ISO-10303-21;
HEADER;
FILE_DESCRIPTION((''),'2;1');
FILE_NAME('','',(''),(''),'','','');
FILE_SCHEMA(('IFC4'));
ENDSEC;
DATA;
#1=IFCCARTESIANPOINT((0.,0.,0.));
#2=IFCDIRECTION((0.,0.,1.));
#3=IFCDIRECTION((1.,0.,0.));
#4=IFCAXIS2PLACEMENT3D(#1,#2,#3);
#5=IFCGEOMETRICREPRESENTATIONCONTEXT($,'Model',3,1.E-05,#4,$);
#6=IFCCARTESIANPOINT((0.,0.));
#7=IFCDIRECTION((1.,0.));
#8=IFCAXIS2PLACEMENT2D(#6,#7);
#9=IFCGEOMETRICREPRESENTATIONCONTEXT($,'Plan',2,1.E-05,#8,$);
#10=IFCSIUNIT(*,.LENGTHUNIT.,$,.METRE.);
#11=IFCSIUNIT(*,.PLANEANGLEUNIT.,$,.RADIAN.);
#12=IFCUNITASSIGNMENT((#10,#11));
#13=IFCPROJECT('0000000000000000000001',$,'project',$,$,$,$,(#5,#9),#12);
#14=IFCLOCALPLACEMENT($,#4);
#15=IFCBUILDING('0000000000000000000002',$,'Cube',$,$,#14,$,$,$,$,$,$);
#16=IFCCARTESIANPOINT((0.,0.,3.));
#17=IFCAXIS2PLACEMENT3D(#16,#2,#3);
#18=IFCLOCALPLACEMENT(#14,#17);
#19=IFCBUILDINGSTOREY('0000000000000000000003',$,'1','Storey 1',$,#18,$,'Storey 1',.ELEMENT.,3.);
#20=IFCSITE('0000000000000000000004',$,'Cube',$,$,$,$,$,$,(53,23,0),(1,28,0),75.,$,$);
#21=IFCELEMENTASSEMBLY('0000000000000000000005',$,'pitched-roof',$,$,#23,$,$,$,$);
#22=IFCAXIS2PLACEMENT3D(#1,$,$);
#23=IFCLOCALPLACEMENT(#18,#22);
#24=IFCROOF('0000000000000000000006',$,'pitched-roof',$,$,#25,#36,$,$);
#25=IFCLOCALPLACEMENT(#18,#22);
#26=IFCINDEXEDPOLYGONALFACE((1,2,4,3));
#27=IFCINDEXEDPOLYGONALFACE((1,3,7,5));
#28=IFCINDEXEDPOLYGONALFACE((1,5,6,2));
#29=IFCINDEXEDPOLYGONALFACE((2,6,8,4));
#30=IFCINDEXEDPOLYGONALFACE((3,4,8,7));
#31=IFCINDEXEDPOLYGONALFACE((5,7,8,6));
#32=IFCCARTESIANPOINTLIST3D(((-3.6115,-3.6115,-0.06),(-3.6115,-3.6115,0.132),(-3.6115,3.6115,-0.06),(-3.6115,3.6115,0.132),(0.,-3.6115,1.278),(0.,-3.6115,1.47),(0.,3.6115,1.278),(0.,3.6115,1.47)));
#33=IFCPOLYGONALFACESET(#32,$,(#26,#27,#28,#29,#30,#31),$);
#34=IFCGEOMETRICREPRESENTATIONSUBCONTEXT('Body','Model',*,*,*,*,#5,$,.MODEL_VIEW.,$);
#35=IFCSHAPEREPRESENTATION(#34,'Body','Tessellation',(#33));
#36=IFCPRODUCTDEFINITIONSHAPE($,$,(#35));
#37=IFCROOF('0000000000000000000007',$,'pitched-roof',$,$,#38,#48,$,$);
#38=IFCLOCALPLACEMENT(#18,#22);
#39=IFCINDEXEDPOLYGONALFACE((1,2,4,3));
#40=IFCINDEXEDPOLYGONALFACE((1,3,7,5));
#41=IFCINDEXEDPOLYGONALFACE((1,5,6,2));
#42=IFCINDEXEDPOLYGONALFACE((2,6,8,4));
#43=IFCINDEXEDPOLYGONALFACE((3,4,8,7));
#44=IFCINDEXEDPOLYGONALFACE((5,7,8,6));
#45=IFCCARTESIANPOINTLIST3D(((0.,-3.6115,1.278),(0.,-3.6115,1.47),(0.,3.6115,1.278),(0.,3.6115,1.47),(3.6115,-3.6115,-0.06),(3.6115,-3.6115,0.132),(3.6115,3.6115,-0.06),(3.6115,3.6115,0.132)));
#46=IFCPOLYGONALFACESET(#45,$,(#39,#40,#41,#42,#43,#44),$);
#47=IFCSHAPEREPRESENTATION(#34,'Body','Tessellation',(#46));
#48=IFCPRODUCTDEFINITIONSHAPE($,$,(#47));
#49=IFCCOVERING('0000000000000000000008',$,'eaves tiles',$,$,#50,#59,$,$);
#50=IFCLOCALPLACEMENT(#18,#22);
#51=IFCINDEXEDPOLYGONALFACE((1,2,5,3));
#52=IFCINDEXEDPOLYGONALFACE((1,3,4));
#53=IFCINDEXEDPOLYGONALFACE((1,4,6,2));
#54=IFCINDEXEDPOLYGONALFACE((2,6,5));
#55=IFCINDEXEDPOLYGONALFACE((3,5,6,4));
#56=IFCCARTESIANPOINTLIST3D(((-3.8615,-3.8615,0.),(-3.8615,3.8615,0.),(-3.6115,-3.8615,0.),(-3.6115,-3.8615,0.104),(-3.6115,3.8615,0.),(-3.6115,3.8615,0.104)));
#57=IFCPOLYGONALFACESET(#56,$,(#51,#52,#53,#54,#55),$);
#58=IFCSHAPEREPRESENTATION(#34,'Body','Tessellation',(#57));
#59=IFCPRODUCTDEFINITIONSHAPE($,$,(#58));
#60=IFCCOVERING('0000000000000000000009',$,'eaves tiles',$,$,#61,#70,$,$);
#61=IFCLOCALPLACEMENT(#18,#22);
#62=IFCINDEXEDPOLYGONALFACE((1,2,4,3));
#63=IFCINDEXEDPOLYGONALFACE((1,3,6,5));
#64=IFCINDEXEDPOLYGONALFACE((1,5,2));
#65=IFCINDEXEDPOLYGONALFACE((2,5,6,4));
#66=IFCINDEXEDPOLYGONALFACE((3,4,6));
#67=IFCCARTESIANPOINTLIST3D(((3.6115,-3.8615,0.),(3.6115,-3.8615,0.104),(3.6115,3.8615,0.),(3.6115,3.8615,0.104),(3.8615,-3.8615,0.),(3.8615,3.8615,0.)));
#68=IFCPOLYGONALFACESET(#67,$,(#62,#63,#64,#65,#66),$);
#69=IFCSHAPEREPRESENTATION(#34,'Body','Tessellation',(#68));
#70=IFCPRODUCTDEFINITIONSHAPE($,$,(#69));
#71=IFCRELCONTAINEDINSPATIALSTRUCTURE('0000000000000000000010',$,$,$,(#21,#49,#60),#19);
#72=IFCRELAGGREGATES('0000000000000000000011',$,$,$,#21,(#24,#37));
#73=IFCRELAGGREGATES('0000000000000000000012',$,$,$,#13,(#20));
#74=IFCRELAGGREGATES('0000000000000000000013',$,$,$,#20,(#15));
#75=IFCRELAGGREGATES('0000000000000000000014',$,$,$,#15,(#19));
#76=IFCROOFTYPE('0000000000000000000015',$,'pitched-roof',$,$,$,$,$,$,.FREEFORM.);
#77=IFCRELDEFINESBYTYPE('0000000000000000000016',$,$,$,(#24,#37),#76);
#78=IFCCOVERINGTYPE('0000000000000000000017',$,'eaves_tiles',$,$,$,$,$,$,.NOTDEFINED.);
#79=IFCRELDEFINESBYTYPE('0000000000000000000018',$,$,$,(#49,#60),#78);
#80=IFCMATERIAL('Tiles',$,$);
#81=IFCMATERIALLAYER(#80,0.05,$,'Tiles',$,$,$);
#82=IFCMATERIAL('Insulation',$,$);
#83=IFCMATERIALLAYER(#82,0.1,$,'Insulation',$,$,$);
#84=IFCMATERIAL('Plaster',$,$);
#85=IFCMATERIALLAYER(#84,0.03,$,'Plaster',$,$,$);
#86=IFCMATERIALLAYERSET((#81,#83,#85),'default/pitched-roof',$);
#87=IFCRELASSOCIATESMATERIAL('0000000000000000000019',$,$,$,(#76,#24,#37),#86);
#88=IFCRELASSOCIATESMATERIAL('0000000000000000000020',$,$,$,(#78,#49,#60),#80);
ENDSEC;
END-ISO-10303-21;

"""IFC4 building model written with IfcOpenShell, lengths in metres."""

from ifc_helpers import new_model, si_unit, frame, origin, origin_with_axes, origin_2d_with_axis, place, context, subcontext, project, spatial, polyline, outline, extrude, material, layer, layer_set, layer_usage, material_profile, profile_set, profile_usage, type_object, element, aggregate, save


model = new_model("IFC4")

# Units and contexts
model_context = context("Model", 3, precision=1e-05, world=origin_with_axes())
plan_context = context("Plan", 2, precision=1e-05, world=origin_2d_with_axis())
body_context = subcontext(model_context, "Body", "Model", "MODEL_VIEW")
ifc_project = project(units=[si_unit("LENGTHUNIT", "METRE"), si_unit("PLANEANGLEUNIT", "RADIAN")], contexts=[model_context, plan_context])

# Site, building, storey
site = spatial("IfcSite", under=ifc_project, Name="Cube", RefLatitude=(53, 23, 0), RefLongitude=(1, 28, 0), RefElevation=75.0)
building_placement = place(None, origin_with_axes())
building = spatial("IfcBuilding", under=site, at=building_placement, Name="Cube")
storey_placement = place(building_placement, frame((0.0, 0.0, 3.0), z_axis=(0.0, 0.0, 1.0), x_axis=(1.0, 0.0, 0.0)))
storey = spatial("IfcBuildingStorey", under=building, at=storey_placement, Name="1", Description="Storey 1", LongName="Storey 1", CompositionType="ELEMENT", Elevation=3.0)

# Element assembly, roofs
assembly_placement = place(storey_placement, frame((0.0, 0.0, -3.0), z_axis=(0.0, 0.0, 1.0), x_axis=(1.0, 0.0, 0.0)))
assembly = element("IfcElementAssembly", 1, at=assembly_placement, inside=storey, Name="pitched-roof")
ifc_material_1 = material(Name="Tiles")
ifc_layer_1 = layer(ifc_material_1, 0.05, Name="Tiles")
ifc_material_2 = material(Name="Insulation")
ifc_layer_2 = layer(ifc_material_2, 0.1, Name="Insulation")
ifc_material_3 = material(Name="Plaster")
ifc_layer_3 = layer(ifc_material_3, 0.03, Name="Plaster")
ifc_layer_set = layer_set([ifc_layer_1, ifc_layer_2, ifc_layer_3], Name="default/pitched-roof")
ifc_layer_usage_1 = layer_usage(ifc_layer_set, "AXIS3", "POSITIVE", 0.0)
roof_type = type_object("IfcRoofType", Name="pitched-roof", PredefinedType="FREEFORM", material=ifc_layer_set)
roof_1_placement = place(assembly_placement, frame((-3.6115, 3.6115, 2.94), z_axis=(-0.347413, 0.0, 0.937712), x_axis=(0.0, -1.0, 0.0)))
roof_1 = element("IfcRoof", 2, at=roof_1_placement, type_object=roof_type, material=ifc_layer_usage_1, Name="pitched-roof", context=body_context, shape_type="SweptSolid", body=[
    extrude(outline(polyline([(0.0, 0.0), (7.223, 0.0), (7.223, 3.8514), (0.0, 3.8514), (0.0, 0.0)])), origin(), (0.0, 0.347413, 0.937712), 0.192),
])
ifc_layer_usage_2 = layer_usage(ifc_layer_set, "AXIS3", "POSITIVE", 0.0)
roof_2_placement = place(assembly_placement, frame((3.6115, -3.6115, 2.94), z_axis=(0.347413, 0.0, 0.937712), x_axis=(0.0, 1.0, 0.0)))
roof_2 = element("IfcRoof", 3, at=roof_2_placement, type_object=roof_type, material=ifc_layer_usage_2, Name="pitched-roof", context=body_context, shape_type="SweptSolid", body=[
    extrude(outline(polyline([(0.0, 0.0), (7.223, 0.0), (7.223, 3.8514), (0.0, 3.8514), (0.0, 0.0)])), origin(), (0.0, 0.347413, 0.937712), 0.192),
])
aggregate(assembly, [roof_1, roof_2])

# Coverings
ifc_material_profile_1 = material_profile(ifc_material_1, outline(polyline([(0.25, 0.0), (0.0, 0.0), (0.0, 0.104), (0.25, 0.0)])))
ifc_profile_set_1 = profile_set([ifc_material_profile_1])
ifc_profile_usage_1 = profile_usage(ifc_profile_set_1)
covering_type_1 = type_object("IfcCoveringType", Name="eaves_tiles", PredefinedType="NOTDEFINED", material=ifc_profile_set_1)
covering_1_placement = place(storey_placement, frame((-3.6115, -3.8615, 0.0), z_axis=(0.0, 1.0, 0.0), x_axis=(-1.0, 0.0, 0.0)))
element("IfcCovering", 4, at=covering_1_placement, inside=storey, type_object=covering_type_1, material=ifc_profile_usage_1, Name="eaves tiles", context=body_context, shape_type="SweptSolid", body=[
    extrude(outline(polyline([(0.25, 0.0), (0.0, 0.0), (0.0, 0.104), (0.25, 0.0)])), origin_with_axes(), (0.0, 0.0, 1.0), 7.723),
])
ifc_profile_usage_2 = profile_usage(ifc_profile_set_1)
covering_2_placement = place(storey_placement, frame((3.6115, 3.8615, 0.0), z_axis=(0.0, -1.0, 0.0), x_axis=(1.0, 0.0, 0.0)))
element("IfcCovering", 5, at=covering_2_placement, inside=storey, type_object=covering_type_1, material=ifc_profile_usage_2, Name="eaves tiles", context=body_context, shape_type="SweptSolid", body=[
    extrude(outline(polyline([(0.25, 0.0), (0.0, 0.0), (0.0, 0.104), (0.25, 0.0)])), origin_with_axes(), (0.0, 0.0, 1.0), 7.723),
])

save(model, "model.ifc")
